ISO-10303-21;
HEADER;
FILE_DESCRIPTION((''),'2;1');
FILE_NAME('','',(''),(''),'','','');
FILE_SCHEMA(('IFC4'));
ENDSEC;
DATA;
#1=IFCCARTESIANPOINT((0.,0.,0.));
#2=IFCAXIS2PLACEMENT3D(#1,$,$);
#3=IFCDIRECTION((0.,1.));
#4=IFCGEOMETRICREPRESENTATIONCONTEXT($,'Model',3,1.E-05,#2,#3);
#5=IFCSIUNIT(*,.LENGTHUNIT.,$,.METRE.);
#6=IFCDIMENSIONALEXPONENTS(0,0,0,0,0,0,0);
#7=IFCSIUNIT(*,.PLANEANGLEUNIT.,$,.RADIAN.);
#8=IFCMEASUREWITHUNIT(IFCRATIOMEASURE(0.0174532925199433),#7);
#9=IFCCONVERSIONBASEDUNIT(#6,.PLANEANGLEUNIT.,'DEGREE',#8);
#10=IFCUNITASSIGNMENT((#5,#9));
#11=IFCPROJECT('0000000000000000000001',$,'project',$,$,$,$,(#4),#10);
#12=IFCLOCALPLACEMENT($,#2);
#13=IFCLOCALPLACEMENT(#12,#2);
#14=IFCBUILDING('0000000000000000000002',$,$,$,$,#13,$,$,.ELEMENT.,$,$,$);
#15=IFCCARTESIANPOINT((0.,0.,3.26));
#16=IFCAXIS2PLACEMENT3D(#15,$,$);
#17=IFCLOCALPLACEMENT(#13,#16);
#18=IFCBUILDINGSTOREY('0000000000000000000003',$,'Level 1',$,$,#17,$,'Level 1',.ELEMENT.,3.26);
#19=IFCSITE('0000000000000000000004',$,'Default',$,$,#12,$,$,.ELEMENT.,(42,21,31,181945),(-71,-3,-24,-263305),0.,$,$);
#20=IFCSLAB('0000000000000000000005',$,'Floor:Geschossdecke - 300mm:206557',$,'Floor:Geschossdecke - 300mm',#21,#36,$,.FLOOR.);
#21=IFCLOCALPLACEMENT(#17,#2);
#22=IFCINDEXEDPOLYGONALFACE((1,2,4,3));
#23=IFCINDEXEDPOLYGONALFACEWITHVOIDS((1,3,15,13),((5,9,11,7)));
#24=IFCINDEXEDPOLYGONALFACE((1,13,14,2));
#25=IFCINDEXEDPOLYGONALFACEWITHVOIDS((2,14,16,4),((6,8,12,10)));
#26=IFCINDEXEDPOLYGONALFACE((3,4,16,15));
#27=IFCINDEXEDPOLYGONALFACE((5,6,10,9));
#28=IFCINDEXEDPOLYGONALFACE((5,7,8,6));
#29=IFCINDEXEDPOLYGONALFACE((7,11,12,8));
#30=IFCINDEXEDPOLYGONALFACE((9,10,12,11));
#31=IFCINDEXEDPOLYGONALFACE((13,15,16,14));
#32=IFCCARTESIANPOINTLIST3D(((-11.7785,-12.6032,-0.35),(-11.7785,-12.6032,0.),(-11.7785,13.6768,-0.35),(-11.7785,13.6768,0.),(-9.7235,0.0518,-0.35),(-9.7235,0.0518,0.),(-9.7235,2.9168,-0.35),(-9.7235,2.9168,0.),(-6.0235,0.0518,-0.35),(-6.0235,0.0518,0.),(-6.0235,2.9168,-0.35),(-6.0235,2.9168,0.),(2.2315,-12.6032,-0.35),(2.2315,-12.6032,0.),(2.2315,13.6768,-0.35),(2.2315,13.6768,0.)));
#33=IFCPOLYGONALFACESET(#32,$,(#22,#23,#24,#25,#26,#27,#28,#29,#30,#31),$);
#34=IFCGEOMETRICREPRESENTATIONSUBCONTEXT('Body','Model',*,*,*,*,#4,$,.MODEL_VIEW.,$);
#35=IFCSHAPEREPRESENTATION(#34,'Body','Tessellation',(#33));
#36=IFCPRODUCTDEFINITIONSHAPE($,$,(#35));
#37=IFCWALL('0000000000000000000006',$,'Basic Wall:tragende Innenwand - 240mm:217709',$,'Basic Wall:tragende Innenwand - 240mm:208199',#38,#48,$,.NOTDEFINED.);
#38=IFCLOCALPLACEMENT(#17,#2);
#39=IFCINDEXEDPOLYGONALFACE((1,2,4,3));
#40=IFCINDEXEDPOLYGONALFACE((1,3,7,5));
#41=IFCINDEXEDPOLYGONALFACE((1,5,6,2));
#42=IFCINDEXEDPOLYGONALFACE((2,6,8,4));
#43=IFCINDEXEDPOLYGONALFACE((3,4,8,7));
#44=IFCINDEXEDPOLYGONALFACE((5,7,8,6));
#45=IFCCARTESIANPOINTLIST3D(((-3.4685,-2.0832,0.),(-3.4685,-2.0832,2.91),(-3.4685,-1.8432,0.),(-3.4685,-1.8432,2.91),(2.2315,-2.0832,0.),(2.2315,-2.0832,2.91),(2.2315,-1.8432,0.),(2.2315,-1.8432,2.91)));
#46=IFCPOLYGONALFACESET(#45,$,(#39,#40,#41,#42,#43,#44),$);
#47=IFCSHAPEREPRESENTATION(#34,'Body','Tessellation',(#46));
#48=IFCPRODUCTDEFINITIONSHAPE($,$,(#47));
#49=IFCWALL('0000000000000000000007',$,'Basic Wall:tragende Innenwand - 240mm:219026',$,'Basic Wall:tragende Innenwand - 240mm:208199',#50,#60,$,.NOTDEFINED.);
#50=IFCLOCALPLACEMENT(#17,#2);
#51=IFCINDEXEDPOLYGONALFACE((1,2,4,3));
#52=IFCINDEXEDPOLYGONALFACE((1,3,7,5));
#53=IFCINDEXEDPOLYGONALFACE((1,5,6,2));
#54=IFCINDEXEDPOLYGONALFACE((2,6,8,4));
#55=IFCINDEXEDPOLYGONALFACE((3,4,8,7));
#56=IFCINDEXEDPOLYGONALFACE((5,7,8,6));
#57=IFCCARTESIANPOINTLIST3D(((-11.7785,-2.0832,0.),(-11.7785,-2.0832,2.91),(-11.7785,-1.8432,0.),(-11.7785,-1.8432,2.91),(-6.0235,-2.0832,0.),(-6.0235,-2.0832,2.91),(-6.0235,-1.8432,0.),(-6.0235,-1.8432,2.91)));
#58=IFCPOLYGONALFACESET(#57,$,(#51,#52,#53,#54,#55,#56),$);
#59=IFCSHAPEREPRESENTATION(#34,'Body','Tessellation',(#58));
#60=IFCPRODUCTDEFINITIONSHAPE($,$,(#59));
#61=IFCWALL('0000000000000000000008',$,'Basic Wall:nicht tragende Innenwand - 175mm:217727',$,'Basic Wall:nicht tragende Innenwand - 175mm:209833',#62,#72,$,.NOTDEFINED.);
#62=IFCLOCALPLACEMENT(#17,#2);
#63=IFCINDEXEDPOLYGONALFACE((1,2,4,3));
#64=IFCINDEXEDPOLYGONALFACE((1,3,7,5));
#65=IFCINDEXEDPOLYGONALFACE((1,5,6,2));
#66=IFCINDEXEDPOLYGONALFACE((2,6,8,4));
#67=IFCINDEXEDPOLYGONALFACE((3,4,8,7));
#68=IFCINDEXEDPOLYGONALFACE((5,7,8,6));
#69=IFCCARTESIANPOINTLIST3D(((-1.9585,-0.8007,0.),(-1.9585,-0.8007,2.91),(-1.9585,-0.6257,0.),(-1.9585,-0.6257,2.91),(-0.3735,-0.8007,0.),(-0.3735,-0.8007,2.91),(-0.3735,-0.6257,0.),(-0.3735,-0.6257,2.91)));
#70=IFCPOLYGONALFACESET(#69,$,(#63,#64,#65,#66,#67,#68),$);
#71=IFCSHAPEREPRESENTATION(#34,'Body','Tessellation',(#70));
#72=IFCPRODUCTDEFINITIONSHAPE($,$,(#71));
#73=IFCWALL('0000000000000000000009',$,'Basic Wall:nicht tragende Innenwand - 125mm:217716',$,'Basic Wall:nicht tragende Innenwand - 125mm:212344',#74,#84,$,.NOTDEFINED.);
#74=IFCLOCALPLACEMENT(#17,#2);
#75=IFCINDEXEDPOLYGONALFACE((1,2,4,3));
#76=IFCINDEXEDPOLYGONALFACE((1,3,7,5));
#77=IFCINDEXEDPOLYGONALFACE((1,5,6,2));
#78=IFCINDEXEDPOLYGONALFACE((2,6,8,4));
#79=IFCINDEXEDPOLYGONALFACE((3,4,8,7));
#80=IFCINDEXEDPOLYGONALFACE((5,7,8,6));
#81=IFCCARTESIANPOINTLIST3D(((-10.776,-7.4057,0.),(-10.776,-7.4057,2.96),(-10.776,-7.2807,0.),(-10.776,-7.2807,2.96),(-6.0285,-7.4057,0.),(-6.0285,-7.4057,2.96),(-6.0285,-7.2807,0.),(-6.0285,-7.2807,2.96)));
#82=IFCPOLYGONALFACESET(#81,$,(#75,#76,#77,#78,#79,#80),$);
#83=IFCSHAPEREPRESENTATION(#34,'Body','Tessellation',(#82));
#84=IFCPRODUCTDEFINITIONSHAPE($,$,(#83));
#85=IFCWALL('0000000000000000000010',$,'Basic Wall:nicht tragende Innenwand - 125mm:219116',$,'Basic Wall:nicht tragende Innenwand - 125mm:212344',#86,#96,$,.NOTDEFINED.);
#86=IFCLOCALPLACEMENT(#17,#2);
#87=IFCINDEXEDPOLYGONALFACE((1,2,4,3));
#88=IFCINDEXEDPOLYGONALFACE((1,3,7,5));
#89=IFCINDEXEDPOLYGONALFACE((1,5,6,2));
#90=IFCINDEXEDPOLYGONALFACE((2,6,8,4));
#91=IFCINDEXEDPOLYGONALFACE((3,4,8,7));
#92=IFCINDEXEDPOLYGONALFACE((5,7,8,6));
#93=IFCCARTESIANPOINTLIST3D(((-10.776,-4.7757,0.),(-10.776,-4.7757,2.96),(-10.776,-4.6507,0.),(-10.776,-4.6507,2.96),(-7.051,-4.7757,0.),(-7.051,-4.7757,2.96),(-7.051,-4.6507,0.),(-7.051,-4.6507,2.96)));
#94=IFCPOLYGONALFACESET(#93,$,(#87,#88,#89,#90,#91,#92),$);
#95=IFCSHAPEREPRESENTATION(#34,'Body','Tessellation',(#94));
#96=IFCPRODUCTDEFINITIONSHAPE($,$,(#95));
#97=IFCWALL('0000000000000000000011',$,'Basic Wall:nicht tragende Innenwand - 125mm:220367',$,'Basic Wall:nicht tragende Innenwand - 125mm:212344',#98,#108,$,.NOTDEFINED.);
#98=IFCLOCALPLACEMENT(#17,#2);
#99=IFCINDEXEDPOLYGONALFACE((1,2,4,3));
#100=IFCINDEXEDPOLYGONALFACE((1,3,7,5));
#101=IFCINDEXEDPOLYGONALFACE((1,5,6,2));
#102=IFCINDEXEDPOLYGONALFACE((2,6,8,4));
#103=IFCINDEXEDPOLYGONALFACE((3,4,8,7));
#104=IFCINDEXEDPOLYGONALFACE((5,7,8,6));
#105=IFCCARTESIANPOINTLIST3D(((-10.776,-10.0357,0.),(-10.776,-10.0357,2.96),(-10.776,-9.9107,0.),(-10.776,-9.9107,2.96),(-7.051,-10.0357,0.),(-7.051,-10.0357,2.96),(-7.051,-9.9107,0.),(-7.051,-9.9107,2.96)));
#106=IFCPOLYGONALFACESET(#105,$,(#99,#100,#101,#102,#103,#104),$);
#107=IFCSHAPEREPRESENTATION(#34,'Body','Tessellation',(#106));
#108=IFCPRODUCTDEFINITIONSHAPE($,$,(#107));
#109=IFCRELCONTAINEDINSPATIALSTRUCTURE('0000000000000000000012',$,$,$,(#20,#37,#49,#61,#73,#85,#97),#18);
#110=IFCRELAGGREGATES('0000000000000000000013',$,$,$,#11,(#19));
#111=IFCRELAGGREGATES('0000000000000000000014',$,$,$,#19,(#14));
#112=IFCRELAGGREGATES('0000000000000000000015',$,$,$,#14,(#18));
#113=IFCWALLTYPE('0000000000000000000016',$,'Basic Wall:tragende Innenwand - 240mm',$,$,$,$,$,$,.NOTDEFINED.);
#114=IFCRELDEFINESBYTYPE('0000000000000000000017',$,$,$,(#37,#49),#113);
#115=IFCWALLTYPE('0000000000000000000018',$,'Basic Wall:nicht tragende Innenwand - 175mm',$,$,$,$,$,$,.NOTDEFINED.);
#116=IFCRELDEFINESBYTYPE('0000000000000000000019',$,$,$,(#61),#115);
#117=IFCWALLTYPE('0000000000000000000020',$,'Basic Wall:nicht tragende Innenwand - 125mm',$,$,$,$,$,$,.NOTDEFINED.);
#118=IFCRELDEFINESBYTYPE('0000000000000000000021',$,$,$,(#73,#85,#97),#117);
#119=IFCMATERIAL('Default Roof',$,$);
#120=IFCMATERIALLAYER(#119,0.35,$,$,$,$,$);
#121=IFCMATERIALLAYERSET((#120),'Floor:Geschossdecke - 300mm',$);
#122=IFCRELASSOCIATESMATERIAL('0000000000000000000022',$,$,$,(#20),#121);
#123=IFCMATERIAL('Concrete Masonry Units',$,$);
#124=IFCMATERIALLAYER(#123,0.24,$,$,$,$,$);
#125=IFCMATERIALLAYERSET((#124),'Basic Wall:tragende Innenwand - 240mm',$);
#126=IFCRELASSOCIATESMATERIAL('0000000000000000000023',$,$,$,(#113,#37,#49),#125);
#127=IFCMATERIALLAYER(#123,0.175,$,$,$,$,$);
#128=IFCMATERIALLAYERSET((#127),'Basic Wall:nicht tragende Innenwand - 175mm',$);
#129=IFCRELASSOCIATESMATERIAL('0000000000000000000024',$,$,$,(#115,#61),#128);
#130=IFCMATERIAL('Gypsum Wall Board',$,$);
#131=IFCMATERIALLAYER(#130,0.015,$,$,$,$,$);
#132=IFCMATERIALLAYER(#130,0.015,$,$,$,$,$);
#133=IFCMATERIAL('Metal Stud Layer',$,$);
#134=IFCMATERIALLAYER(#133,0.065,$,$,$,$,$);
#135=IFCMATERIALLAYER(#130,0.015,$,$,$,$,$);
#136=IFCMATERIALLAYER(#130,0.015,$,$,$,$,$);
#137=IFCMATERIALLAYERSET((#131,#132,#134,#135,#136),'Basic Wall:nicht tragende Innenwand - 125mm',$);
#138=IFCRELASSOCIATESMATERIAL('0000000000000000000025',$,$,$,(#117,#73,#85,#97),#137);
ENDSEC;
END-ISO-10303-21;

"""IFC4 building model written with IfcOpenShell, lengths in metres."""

from ifc_helpers import new_model, entity, si_unit, converted_unit, direction, frame, frame_2d, origin, origin_2d_with_axis, place, context, subcontext, project, spatial, rectangle, extrude, material, layer, layer_set, layer_usage, type_object, element, save


model = new_model("IFC4")

# Units and contexts
model_context = context("Model", 3, precision=1e-05, world=origin(), true_north=direction((0.0, 1.0)))
body_context = subcontext(model_context, "Body", "Model", "MODEL_VIEW")
ifc_project = project(units=[si_unit("LENGTHUNIT", "METRE"), converted_unit("PLANEANGLEUNIT", "DEGREE", entity("IfcRatioMeasure", 0.0174532925199433), si_unit("PLANEANGLEUNIT", "RADIAN"), dimensions=[0, 0, 0, 0, 0, 0, 0])], contexts=[model_context])

# Site, building, storey
site_placement = place(None, origin())
site = spatial("IfcSite", under=ifc_project, at=site_placement, Name="Default", CompositionType="ELEMENT", RefLatitude=(42, 21, 31, 181945), RefLongitude=(-71, -3, -24, -263305), RefElevation=0.0)
building_placement = place(site_placement, origin())
building = spatial("IfcBuilding", under=site, at=building_placement, CompositionType="ELEMENT")
storey_placement = place(building_placement, frame((0.0, 0.0, 3.26)))
storey = spatial("IfcBuildingStorey", under=building, at=storey_placement, Name="Level 1", LongName="Level 1", CompositionType="ELEMENT", Elevation=3.26)

# Slab, opening
ifc_material_1 = material(Name="Default Roof")
ifc_layer_1 = layer(ifc_material_1, 0.35)
ifc_layer_set_1 = layer_set([ifc_layer_1], Name="Floor:Geschossdecke - 300mm")
ifc_layer_usage_1 = layer_usage(ifc_layer_set_1, "AXIS3", "POSITIVE", 0.0)
slab_placement = place(storey_placement, frame((-11.7785, -12.6032, -0.35)))
slab = element("IfcSlab", 1, at=slab_placement, inside=storey, material=ifc_layer_usage_1, Name="Floor:Geschossdecke - 300mm:206557", ObjectType="Floor:Geschossdecke - 300mm", PredefinedType="FLOOR", context=body_context, shape_type="SweptSolid", body=[
    extrude(rectangle(XDim=26.28, YDim=14.01, at=frame_2d((0.0, 0.0), x_axis=(0.0, -1.0))), frame((7.005, 13.14, 0.35), z_axis=(0.0, 0.0, -1.0), x_axis=(-1.0, 0.0, 0.0)), (0.0, 0.0, 1.0), 0.35),
])
opening_1_placement = place(slab_placement, frame((3.905, 14.0875, 0.35)))
element("IfcOpeningElement", 2, at=opening_1_placement, cuts=slab, ObjectType="Opening", context=body_context, shape_type="SweptSolid", body=[
    extrude(rectangle(XDim=3.7, YDim=2.865, at=origin_2d_with_axis()), frame((0.0, 0.0, 0.0), z_axis=(0.0, 0.0, -1.0), x_axis=(1.0, 0.0, 0.0)), (0.0, 0.0, 1.0), 0.35),
])

# Walls
ifc_material_2 = material(Name="Concrete Masonry Units")
ifc_layer_2 = layer(ifc_material_2, 0.24)
ifc_layer_set_2 = layer_set([ifc_layer_2], Name="Basic Wall:tragende Innenwand - 240mm")
ifc_layer_usage_2 = layer_usage(ifc_layer_set_2, "AXIS2", "NEGATIVE", 0.12)
wall_type_1 = type_object("IfcWallType", Name="Basic Wall:tragende Innenwand - 240mm", PredefinedType="NOTDEFINED", material=ifc_layer_set_2)
wall_1_placement = place(storey_placement, frame((-3.4685, -1.9632, 0.0)))
element("IfcWall", 3, at=wall_1_placement, inside=storey, type_object=wall_type_1, material=ifc_layer_usage_2, Name="Basic Wall:tragende Innenwand - 240mm:217709", ObjectType="Basic Wall:tragende Innenwand - 240mm:208199", PredefinedType="NOTDEFINED", context=body_context, shape_type="SweptSolid", body=[
    extrude(rectangle(XDim=5.7, YDim=0.24, at=frame_2d((2.85, 0.0), x_axis=(-1.0, 0.0))), origin(), (0.0, 0.0, 1.0), 2.91),
])
ifc_layer_usage_3 = layer_usage(ifc_layer_set_2, "AXIS2", "POSITIVE", -0.12)
wall_2_placement = place(storey_placement, frame((-11.7785, -1.9632, 0.0)))
element("IfcWall", 4, at=wall_2_placement, inside=storey, type_object=wall_type_1, material=ifc_layer_usage_3, Name="Basic Wall:tragende Innenwand - 240mm:219026", ObjectType="Basic Wall:tragende Innenwand - 240mm:208199", PredefinedType="NOTDEFINED", context=body_context, shape_type="SweptSolid", body=[
    extrude(rectangle(XDim=5.755, YDim=0.24, at=frame_2d((2.8775, 0.0), x_axis=(-1.0, 0.0))), origin(), (0.0, 0.0, 1.0), 2.91),
])
ifc_layer_3 = layer(ifc_material_2, 0.175)
ifc_layer_set_3 = layer_set([ifc_layer_3], Name="Basic Wall:nicht tragende Innenwand - 175mm")
ifc_layer_usage_4 = layer_usage(ifc_layer_set_3, "AXIS2", "NEGATIVE", 0.0875)
wall_type_2 = type_object("IfcWallType", Name="Basic Wall:nicht tragende Innenwand - 175mm", PredefinedType="NOTDEFINED", material=ifc_layer_set_3)
wall_3_placement = place(storey_placement, frame((-1.9585, -0.7132, 0.0)))
element("IfcWall", 5, at=wall_3_placement, inside=storey, type_object=wall_type_2, material=ifc_layer_usage_4, Name="Basic Wall:nicht tragende Innenwand - 175mm:217727", ObjectType="Basic Wall:nicht tragende Innenwand - 175mm:209833", PredefinedType="NOTDEFINED", context=body_context, shape_type="SweptSolid", body=[
    extrude(rectangle(XDim=1.585, YDim=0.175, at=frame_2d((0.7925, 0.0), x_axis=(-1.0, 0.0))), origin(), (0.0, 0.0, 1.0), 2.91),
])
ifc_material_3 = material(Name="Gypsum Wall Board")
ifc_layer_4 = layer(ifc_material_3, 0.015)
ifc_layer_5 = layer(ifc_material_3, 0.015)
ifc_material_4 = material(Name="Metal Stud Layer")
ifc_layer_6 = layer(ifc_material_4, 0.065)
ifc_layer_7 = layer(ifc_material_3, 0.015)
ifc_layer_8 = layer(ifc_material_3, 0.015)
ifc_layer_set_4 = layer_set([ifc_layer_4, ifc_layer_5, ifc_layer_6, ifc_layer_7, ifc_layer_8], Name="Basic Wall:nicht tragende Innenwand - 125mm")
ifc_layer_usage_5 = layer_usage(ifc_layer_set_4, "AXIS2", "NEGATIVE", 0.0625)
wall_type_3 = type_object("IfcWallType", Name="Basic Wall:nicht tragende Innenwand - 125mm", PredefinedType="NOTDEFINED", material=ifc_layer_set_4)
wall_4_placement = place(storey_placement, frame((-10.776, -7.3432, 0.0)))
element("IfcWall", 6, at=wall_4_placement, inside=storey, type_object=wall_type_3, material=ifc_layer_usage_5, Name="Basic Wall:nicht tragende Innenwand - 125mm:217716", ObjectType="Basic Wall:nicht tragende Innenwand - 125mm:212344", PredefinedType="NOTDEFINED", context=body_context, shape_type="SweptSolid", body=[
    extrude(rectangle(XDim=4.7475, YDim=0.125, at=frame_2d((2.3737, 0.0), x_axis=(-1.0, 0.0))), origin(), (0.0, 0.0, 1.0), 2.96),
])
ifc_layer_usage_6 = layer_usage(ifc_layer_set_4, "AXIS2", "POSITIVE", -0.0625)
wall_5_placement = place(storey_placement, frame((-10.776, -4.7132, 0.0)))
element("IfcWall", 7, at=wall_5_placement, inside=storey, type_object=wall_type_3, material=ifc_layer_usage_6, Name="Basic Wall:nicht tragende Innenwand - 125mm:219116", ObjectType="Basic Wall:nicht tragende Innenwand - 125mm:212344", PredefinedType="NOTDEFINED", context=body_context, shape_type="SweptSolid", body=[
    extrude(rectangle(XDim=3.725, YDim=0.125, at=frame_2d((1.8625, 0.0), x_axis=(-1.0, 0.0))), origin(), (0.0, 0.0, 1.0), 2.96),
])
ifc_layer_usage_7 = layer_usage(ifc_layer_set_4, "AXIS2", "NEGATIVE", 0.0625)
wall_6_placement = place(storey_placement, frame((-10.776, -9.9732, 0.0)))
element("IfcWall", 8, at=wall_6_placement, inside=storey, type_object=wall_type_3, material=ifc_layer_usage_7, Name="Basic Wall:nicht tragende Innenwand - 125mm:220367", ObjectType="Basic Wall:nicht tragende Innenwand - 125mm:212344", PredefinedType="NOTDEFINED", context=body_context, shape_type="SweptSolid", body=[
    extrude(rectangle(XDim=3.725, YDim=0.125, at=frame_2d((1.8625, 0.0), x_axis=(-1.0, 0.0))), origin(), (0.0, 0.0, 1.0), 2.96),
])

save(model, "model.ifc")
